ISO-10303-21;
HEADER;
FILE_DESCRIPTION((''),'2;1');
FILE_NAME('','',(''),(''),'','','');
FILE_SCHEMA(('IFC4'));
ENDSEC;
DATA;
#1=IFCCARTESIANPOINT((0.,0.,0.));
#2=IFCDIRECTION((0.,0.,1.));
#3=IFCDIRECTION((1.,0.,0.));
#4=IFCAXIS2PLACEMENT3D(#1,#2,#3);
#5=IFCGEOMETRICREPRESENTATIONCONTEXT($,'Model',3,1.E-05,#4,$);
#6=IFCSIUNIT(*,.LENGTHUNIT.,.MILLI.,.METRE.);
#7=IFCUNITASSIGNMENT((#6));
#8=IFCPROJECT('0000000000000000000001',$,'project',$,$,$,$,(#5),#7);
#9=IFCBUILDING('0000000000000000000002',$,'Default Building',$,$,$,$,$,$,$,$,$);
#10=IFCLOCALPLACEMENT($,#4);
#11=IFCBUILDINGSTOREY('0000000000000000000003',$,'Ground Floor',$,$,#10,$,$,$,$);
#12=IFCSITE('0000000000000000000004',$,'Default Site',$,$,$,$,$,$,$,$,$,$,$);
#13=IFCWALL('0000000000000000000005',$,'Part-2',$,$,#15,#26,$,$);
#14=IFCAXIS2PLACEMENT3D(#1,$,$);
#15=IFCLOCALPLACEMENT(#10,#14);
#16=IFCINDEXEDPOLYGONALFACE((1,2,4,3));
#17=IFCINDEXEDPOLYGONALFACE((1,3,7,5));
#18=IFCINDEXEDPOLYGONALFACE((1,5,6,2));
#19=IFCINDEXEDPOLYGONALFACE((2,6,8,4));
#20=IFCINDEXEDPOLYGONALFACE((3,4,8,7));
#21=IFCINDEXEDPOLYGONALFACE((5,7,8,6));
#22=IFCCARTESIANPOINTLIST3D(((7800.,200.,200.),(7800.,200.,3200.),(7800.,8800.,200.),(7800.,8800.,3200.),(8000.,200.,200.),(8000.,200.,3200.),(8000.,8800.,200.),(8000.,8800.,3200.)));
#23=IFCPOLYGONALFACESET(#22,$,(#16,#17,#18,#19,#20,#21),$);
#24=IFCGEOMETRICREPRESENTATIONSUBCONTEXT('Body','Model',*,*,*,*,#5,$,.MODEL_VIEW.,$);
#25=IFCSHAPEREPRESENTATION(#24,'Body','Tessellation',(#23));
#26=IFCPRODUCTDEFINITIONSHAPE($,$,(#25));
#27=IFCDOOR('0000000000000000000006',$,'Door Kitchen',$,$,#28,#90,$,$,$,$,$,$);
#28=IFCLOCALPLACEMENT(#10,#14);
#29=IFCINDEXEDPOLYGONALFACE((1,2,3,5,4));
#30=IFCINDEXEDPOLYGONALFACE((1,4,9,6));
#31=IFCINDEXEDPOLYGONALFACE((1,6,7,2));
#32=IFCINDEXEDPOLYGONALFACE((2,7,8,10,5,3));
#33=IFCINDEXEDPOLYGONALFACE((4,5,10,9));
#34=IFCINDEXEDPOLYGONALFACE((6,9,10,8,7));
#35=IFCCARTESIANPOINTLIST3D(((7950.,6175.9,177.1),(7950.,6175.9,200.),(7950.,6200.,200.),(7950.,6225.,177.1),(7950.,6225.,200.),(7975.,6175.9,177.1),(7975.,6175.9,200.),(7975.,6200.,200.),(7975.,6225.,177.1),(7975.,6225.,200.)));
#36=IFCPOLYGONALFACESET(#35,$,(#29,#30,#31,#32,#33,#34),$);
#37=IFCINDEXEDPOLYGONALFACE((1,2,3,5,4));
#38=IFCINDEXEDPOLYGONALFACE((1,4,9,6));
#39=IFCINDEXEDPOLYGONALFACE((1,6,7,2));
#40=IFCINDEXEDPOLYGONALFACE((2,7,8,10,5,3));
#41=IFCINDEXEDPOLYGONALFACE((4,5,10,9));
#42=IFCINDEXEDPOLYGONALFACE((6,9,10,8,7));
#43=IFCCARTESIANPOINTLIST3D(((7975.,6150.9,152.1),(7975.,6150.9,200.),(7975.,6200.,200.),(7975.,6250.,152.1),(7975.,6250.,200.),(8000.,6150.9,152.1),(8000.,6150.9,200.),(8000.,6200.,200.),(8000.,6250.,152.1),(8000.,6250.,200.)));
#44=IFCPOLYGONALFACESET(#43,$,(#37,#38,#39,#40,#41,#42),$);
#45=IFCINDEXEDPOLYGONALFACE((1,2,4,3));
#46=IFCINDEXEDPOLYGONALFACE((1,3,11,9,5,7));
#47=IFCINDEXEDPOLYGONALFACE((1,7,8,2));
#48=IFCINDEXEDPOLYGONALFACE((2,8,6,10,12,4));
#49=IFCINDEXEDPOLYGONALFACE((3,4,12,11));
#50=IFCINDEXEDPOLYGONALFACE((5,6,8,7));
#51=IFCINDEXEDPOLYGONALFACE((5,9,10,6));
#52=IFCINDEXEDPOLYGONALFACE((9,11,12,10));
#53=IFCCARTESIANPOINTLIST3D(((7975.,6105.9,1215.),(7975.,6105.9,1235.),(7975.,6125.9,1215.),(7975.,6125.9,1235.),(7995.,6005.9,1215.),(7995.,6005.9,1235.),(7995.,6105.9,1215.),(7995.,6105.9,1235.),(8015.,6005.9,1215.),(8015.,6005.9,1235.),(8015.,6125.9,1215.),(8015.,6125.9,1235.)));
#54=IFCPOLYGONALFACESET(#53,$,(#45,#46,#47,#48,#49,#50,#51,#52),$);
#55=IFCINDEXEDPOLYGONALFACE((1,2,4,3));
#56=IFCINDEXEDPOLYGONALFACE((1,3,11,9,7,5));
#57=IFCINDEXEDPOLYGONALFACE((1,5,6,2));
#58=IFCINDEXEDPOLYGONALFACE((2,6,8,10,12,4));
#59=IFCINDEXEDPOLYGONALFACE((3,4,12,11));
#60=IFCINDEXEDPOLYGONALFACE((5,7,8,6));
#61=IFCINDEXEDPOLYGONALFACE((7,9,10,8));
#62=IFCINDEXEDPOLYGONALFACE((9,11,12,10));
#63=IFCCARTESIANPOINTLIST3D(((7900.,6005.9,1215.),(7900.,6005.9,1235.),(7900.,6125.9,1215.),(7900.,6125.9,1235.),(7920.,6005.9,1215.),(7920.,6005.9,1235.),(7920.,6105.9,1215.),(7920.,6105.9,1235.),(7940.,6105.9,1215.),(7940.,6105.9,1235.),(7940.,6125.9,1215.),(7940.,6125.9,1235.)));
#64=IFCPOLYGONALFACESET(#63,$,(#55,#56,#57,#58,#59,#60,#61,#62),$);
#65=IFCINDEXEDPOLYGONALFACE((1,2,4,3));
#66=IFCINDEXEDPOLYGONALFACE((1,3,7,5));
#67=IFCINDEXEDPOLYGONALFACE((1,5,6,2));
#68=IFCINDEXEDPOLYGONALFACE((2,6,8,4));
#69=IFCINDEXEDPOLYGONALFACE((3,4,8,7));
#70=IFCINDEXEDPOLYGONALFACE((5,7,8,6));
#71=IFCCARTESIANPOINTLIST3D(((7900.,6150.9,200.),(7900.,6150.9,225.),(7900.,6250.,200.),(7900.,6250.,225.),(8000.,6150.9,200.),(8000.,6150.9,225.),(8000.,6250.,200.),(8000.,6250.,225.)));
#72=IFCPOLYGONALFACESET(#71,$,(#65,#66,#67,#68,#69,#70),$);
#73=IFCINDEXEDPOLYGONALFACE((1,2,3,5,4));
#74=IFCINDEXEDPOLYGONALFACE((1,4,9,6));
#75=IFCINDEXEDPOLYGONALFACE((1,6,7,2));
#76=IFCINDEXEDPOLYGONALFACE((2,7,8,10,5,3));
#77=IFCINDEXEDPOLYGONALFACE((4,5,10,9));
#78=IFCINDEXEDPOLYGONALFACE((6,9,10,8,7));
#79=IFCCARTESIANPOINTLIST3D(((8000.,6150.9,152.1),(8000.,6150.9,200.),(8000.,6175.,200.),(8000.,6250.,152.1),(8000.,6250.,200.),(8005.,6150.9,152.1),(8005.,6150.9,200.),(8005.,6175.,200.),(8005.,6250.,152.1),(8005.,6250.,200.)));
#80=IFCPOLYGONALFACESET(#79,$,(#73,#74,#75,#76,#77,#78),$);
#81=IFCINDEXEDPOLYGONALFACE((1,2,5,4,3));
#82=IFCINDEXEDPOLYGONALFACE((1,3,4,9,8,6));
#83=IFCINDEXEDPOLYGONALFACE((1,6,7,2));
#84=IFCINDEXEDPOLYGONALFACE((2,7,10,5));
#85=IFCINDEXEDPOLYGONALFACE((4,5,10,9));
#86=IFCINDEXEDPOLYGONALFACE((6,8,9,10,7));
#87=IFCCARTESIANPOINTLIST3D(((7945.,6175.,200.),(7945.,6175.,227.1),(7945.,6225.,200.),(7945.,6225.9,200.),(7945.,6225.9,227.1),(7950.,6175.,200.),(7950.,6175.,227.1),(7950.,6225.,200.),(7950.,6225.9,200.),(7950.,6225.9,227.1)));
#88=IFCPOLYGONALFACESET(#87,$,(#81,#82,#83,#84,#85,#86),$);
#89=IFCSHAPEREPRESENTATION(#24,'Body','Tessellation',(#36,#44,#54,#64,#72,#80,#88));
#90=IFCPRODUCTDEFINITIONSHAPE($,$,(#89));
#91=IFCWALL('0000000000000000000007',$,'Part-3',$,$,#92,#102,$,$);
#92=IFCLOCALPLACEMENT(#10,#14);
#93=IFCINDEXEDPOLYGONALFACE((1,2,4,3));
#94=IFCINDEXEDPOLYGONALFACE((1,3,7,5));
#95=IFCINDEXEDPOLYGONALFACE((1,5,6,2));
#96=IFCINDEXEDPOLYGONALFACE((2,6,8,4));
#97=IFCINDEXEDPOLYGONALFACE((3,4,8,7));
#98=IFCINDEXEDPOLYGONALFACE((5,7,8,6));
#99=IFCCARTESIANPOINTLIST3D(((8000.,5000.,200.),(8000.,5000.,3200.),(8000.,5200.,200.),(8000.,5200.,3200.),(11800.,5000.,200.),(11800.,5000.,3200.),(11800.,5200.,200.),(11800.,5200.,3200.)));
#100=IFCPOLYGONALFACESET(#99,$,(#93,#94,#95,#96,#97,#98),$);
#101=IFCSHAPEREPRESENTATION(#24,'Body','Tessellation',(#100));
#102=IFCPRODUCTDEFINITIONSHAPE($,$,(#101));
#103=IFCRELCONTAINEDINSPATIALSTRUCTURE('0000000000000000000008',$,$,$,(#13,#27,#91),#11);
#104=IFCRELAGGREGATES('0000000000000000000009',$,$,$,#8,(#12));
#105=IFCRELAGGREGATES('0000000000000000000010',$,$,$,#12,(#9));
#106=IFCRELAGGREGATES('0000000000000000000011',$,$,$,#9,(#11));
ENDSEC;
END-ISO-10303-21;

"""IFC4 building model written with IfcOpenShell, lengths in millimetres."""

from ifc_helpers import new_model, si_unit, frame, origin_with_axes, place, context, subcontext, project, spatial, line, indexed_curve, outline, extrude, element, fill, save


model = new_model("IFC4")

# Units and contexts
model_context = context("Model", 3, precision=1e-05, world=origin_with_axes())
body_context = subcontext(model_context, "Body", "Model", "MODEL_VIEW")
ifc_project = project(units=[si_unit("LENGTHUNIT", "METRE", prefix="MILLI")], contexts=[model_context])

# Site, building, storey
site = spatial("IfcSite", under=ifc_project, Name="Default Site")
building = spatial("IfcBuilding", under=site, Name="Default Building")
storey_placement = place(None, origin_with_axes())
storey = spatial("IfcBuildingStorey", under=building, at=storey_placement, Name="Ground Floor")

# Wall, opening, door
wall_1_placement = place(storey_placement, frame((0.0, 0.0, 200.0), z_axis=(0.0, 0.0, 1.0), x_axis=(1.0, 0.0, 0.0)))
wall_1 = element("IfcWall", 1, at=wall_1_placement, inside=storey, Name="Part-2", context=body_context, shape_type="SweptSolid", body=[
    extrude(outline(indexed_curve([(8000.0, 200.0), (8000.0, 8800.0), (7800.0, 8800.0), (7800.0, 200.0), (8000.0, 200.0)])), None, (0.0, 0.0, 1.0), 3000.0),
])
opening_1_placement = place(wall_1_placement, origin_with_axes())
opening_1 = element("IfcOpeningElement", 2, at=opening_1_placement, cuts=wall_1, context=body_context, shape_type="SweptSolid", body=[
    extrude(outline(indexed_curve([(8000.0, 6200.0), (8200.0, 6200.0), (8200.0, 7100.0), (8000.0, 7100.0), (8000.0, 6200.0)])), None, (0.0, 0.0, 1.0), 2100.0),
])
door_1_placement = place(storey_placement, frame((8000.0, 6200.0, 200.0), z_axis=(0.0, 0.0, 1.0), x_axis=(0.0, 1.0, 0.0)))
door_1 = element("IfcDoor", 3, at=door_1_placement, inside=storey, Name="Door Kitchen", context=body_context, shape_type="SweptSolid", body=[
    extrude(outline(indexed_curve([(0.0, 0.0), (0.0, 2.1), (0.9, 2.1), (0.9, 0.0), (-24.1, 0.0), (-24.1, -22.9), (25.0, -22.9), (25.0, 0.0)], segments=[line(1, 2, 3, 4, 5, 6, 7, 8, 1)])), frame((0.0, 25.0, 0.0), z_axis=(0.0, -1.0, 0.0), x_axis=(1.0, 0.0, 0.0)), (0.0, 0.0, -1.0), 25.0),
    extrude(outline(indexed_curve([(0.0, 0.0), (0.0, 2.1), (0.9, 2.1), (0.9, 0.0), (-49.1, 0.0), (-49.1, -47.9), (50.0, -47.9), (50.0, 0.0)], segments=[line(1, 2, 3, 4, 5, 6, 7, 8, 1)])), frame((0.0, 0.0, 0.0), z_axis=(0.0, -1.0, 0.0), x_axis=(1.0, 0.0, 0.0)), (0.0, 0.0, -1.0), 25.0),
    extrude(outline(indexed_curve([(0.0, 0.0), (-49.1, 0.0), (-49.1, 35.0), (0.0, 35.0)], segments=[line(1, 2, 3, 4, 1)])), frame((25.0, 25.0, 25.0), z_axis=(0.0, 0.0, 1.0), x_axis=(1.0, 0.0, 0.0)), (0.0, 0.0, 1.0), -47.9),
    extrude(outline(indexed_curve([(0.0, 0.0), (0.0, -40.0), (-120.0, -40.0), (-120.0, -20.0), (-20.0, -20.0), (-20.0, 0.0)], segments=[line(1, 2, 3, 4, 5, 6, 1)])), frame((-74.1, 25.0, 1015.0), z_axis=(0.0, 0.0, 1.0), x_axis=(1.0, 0.0, 0.0)), (0.0, 0.0, 1.0), 20.0),
    extrude(outline(indexed_curve([(0.0, 0.0), (0.0, 40.0), (-120.0, 40.0), (-120.0, 20.0), (-20.0, 20.0), (-20.0, 0.0)], segments=[line(1, 2, 3, 4, 5, 6, 1)])), frame((-74.1, 60.0, 1015.0), z_axis=(0.0, 0.0, 1.0), x_axis=(1.0, 0.0, 0.0)), (0.0, 0.0, 1.0), 20.0),
    extrude(outline(indexed_curve([(0.0, 0.0), (-99.1, 0.0), (-99.1, 100.0), (0.0, 100.0)], segments=[line(1, 2, 3, 4, 1)])), frame((50.0, 0.0, 0.0), z_axis=(0.0, 0.0, 1.0), x_axis=(1.0, 0.0, 0.0)), (0.0, 0.0, 1.0), 25.0),
    extrude(outline(indexed_curve([(0.0, 0.0), (0.0, 27.1), (50.9, 27.1), (50.9, 0.0), (-24.1, 0.0), (-24.1, -47.9), (75.0, -47.9), (75.0, 0.0)], segments=[line(1, 2, 3, 4, 5, 6, 7, 8, 1)])), frame((-25.0, -5.0, 0.0), z_axis=(0.0, -1.0, 0.0), x_axis=(1.0, 0.0, 0.0)), (0.0, 0.0, -1.0), 5.0),
    extrude(outline(indexed_curve([(0.0, 0.0), (0.0, 27.1), (50.9, 27.1), (50.9, 0.0), (0.9, 0.0), (0.9, -22.9), (50.0, -22.9), (50.0, 0.0)], segments=[line(1, 2, 3, 4, 5, 6, 7, 8, 1)])), frame((-25.0, 50.0, 0.0), z_axis=(0.0, -1.0, 0.0), x_axis=(1.0, 0.0, 0.0)), (0.0, 0.0, -1.0), 5.0),
])
fill(opening_1, door_1)

# Wall
wall_2_placement = place(storey_placement, frame((0.0, 0.0, 200.0), z_axis=(0.0, 0.0, 1.0), x_axis=(1.0, 0.0, 0.0)))
element("IfcWall", 4, at=wall_2_placement, inside=storey, Name="Part-3", context=body_context, shape_type="SweptSolid", body=[
    extrude(outline(indexed_curve([(8000.0, 5000.0), (11800.0, 5000.0), (11800.0, 5200.0), (8000.0, 5200.0), (8000.0, 5000.0)])), None, (0.0, 0.0, 1.0), 3000.0),
])

save(model, "model.ifc")
